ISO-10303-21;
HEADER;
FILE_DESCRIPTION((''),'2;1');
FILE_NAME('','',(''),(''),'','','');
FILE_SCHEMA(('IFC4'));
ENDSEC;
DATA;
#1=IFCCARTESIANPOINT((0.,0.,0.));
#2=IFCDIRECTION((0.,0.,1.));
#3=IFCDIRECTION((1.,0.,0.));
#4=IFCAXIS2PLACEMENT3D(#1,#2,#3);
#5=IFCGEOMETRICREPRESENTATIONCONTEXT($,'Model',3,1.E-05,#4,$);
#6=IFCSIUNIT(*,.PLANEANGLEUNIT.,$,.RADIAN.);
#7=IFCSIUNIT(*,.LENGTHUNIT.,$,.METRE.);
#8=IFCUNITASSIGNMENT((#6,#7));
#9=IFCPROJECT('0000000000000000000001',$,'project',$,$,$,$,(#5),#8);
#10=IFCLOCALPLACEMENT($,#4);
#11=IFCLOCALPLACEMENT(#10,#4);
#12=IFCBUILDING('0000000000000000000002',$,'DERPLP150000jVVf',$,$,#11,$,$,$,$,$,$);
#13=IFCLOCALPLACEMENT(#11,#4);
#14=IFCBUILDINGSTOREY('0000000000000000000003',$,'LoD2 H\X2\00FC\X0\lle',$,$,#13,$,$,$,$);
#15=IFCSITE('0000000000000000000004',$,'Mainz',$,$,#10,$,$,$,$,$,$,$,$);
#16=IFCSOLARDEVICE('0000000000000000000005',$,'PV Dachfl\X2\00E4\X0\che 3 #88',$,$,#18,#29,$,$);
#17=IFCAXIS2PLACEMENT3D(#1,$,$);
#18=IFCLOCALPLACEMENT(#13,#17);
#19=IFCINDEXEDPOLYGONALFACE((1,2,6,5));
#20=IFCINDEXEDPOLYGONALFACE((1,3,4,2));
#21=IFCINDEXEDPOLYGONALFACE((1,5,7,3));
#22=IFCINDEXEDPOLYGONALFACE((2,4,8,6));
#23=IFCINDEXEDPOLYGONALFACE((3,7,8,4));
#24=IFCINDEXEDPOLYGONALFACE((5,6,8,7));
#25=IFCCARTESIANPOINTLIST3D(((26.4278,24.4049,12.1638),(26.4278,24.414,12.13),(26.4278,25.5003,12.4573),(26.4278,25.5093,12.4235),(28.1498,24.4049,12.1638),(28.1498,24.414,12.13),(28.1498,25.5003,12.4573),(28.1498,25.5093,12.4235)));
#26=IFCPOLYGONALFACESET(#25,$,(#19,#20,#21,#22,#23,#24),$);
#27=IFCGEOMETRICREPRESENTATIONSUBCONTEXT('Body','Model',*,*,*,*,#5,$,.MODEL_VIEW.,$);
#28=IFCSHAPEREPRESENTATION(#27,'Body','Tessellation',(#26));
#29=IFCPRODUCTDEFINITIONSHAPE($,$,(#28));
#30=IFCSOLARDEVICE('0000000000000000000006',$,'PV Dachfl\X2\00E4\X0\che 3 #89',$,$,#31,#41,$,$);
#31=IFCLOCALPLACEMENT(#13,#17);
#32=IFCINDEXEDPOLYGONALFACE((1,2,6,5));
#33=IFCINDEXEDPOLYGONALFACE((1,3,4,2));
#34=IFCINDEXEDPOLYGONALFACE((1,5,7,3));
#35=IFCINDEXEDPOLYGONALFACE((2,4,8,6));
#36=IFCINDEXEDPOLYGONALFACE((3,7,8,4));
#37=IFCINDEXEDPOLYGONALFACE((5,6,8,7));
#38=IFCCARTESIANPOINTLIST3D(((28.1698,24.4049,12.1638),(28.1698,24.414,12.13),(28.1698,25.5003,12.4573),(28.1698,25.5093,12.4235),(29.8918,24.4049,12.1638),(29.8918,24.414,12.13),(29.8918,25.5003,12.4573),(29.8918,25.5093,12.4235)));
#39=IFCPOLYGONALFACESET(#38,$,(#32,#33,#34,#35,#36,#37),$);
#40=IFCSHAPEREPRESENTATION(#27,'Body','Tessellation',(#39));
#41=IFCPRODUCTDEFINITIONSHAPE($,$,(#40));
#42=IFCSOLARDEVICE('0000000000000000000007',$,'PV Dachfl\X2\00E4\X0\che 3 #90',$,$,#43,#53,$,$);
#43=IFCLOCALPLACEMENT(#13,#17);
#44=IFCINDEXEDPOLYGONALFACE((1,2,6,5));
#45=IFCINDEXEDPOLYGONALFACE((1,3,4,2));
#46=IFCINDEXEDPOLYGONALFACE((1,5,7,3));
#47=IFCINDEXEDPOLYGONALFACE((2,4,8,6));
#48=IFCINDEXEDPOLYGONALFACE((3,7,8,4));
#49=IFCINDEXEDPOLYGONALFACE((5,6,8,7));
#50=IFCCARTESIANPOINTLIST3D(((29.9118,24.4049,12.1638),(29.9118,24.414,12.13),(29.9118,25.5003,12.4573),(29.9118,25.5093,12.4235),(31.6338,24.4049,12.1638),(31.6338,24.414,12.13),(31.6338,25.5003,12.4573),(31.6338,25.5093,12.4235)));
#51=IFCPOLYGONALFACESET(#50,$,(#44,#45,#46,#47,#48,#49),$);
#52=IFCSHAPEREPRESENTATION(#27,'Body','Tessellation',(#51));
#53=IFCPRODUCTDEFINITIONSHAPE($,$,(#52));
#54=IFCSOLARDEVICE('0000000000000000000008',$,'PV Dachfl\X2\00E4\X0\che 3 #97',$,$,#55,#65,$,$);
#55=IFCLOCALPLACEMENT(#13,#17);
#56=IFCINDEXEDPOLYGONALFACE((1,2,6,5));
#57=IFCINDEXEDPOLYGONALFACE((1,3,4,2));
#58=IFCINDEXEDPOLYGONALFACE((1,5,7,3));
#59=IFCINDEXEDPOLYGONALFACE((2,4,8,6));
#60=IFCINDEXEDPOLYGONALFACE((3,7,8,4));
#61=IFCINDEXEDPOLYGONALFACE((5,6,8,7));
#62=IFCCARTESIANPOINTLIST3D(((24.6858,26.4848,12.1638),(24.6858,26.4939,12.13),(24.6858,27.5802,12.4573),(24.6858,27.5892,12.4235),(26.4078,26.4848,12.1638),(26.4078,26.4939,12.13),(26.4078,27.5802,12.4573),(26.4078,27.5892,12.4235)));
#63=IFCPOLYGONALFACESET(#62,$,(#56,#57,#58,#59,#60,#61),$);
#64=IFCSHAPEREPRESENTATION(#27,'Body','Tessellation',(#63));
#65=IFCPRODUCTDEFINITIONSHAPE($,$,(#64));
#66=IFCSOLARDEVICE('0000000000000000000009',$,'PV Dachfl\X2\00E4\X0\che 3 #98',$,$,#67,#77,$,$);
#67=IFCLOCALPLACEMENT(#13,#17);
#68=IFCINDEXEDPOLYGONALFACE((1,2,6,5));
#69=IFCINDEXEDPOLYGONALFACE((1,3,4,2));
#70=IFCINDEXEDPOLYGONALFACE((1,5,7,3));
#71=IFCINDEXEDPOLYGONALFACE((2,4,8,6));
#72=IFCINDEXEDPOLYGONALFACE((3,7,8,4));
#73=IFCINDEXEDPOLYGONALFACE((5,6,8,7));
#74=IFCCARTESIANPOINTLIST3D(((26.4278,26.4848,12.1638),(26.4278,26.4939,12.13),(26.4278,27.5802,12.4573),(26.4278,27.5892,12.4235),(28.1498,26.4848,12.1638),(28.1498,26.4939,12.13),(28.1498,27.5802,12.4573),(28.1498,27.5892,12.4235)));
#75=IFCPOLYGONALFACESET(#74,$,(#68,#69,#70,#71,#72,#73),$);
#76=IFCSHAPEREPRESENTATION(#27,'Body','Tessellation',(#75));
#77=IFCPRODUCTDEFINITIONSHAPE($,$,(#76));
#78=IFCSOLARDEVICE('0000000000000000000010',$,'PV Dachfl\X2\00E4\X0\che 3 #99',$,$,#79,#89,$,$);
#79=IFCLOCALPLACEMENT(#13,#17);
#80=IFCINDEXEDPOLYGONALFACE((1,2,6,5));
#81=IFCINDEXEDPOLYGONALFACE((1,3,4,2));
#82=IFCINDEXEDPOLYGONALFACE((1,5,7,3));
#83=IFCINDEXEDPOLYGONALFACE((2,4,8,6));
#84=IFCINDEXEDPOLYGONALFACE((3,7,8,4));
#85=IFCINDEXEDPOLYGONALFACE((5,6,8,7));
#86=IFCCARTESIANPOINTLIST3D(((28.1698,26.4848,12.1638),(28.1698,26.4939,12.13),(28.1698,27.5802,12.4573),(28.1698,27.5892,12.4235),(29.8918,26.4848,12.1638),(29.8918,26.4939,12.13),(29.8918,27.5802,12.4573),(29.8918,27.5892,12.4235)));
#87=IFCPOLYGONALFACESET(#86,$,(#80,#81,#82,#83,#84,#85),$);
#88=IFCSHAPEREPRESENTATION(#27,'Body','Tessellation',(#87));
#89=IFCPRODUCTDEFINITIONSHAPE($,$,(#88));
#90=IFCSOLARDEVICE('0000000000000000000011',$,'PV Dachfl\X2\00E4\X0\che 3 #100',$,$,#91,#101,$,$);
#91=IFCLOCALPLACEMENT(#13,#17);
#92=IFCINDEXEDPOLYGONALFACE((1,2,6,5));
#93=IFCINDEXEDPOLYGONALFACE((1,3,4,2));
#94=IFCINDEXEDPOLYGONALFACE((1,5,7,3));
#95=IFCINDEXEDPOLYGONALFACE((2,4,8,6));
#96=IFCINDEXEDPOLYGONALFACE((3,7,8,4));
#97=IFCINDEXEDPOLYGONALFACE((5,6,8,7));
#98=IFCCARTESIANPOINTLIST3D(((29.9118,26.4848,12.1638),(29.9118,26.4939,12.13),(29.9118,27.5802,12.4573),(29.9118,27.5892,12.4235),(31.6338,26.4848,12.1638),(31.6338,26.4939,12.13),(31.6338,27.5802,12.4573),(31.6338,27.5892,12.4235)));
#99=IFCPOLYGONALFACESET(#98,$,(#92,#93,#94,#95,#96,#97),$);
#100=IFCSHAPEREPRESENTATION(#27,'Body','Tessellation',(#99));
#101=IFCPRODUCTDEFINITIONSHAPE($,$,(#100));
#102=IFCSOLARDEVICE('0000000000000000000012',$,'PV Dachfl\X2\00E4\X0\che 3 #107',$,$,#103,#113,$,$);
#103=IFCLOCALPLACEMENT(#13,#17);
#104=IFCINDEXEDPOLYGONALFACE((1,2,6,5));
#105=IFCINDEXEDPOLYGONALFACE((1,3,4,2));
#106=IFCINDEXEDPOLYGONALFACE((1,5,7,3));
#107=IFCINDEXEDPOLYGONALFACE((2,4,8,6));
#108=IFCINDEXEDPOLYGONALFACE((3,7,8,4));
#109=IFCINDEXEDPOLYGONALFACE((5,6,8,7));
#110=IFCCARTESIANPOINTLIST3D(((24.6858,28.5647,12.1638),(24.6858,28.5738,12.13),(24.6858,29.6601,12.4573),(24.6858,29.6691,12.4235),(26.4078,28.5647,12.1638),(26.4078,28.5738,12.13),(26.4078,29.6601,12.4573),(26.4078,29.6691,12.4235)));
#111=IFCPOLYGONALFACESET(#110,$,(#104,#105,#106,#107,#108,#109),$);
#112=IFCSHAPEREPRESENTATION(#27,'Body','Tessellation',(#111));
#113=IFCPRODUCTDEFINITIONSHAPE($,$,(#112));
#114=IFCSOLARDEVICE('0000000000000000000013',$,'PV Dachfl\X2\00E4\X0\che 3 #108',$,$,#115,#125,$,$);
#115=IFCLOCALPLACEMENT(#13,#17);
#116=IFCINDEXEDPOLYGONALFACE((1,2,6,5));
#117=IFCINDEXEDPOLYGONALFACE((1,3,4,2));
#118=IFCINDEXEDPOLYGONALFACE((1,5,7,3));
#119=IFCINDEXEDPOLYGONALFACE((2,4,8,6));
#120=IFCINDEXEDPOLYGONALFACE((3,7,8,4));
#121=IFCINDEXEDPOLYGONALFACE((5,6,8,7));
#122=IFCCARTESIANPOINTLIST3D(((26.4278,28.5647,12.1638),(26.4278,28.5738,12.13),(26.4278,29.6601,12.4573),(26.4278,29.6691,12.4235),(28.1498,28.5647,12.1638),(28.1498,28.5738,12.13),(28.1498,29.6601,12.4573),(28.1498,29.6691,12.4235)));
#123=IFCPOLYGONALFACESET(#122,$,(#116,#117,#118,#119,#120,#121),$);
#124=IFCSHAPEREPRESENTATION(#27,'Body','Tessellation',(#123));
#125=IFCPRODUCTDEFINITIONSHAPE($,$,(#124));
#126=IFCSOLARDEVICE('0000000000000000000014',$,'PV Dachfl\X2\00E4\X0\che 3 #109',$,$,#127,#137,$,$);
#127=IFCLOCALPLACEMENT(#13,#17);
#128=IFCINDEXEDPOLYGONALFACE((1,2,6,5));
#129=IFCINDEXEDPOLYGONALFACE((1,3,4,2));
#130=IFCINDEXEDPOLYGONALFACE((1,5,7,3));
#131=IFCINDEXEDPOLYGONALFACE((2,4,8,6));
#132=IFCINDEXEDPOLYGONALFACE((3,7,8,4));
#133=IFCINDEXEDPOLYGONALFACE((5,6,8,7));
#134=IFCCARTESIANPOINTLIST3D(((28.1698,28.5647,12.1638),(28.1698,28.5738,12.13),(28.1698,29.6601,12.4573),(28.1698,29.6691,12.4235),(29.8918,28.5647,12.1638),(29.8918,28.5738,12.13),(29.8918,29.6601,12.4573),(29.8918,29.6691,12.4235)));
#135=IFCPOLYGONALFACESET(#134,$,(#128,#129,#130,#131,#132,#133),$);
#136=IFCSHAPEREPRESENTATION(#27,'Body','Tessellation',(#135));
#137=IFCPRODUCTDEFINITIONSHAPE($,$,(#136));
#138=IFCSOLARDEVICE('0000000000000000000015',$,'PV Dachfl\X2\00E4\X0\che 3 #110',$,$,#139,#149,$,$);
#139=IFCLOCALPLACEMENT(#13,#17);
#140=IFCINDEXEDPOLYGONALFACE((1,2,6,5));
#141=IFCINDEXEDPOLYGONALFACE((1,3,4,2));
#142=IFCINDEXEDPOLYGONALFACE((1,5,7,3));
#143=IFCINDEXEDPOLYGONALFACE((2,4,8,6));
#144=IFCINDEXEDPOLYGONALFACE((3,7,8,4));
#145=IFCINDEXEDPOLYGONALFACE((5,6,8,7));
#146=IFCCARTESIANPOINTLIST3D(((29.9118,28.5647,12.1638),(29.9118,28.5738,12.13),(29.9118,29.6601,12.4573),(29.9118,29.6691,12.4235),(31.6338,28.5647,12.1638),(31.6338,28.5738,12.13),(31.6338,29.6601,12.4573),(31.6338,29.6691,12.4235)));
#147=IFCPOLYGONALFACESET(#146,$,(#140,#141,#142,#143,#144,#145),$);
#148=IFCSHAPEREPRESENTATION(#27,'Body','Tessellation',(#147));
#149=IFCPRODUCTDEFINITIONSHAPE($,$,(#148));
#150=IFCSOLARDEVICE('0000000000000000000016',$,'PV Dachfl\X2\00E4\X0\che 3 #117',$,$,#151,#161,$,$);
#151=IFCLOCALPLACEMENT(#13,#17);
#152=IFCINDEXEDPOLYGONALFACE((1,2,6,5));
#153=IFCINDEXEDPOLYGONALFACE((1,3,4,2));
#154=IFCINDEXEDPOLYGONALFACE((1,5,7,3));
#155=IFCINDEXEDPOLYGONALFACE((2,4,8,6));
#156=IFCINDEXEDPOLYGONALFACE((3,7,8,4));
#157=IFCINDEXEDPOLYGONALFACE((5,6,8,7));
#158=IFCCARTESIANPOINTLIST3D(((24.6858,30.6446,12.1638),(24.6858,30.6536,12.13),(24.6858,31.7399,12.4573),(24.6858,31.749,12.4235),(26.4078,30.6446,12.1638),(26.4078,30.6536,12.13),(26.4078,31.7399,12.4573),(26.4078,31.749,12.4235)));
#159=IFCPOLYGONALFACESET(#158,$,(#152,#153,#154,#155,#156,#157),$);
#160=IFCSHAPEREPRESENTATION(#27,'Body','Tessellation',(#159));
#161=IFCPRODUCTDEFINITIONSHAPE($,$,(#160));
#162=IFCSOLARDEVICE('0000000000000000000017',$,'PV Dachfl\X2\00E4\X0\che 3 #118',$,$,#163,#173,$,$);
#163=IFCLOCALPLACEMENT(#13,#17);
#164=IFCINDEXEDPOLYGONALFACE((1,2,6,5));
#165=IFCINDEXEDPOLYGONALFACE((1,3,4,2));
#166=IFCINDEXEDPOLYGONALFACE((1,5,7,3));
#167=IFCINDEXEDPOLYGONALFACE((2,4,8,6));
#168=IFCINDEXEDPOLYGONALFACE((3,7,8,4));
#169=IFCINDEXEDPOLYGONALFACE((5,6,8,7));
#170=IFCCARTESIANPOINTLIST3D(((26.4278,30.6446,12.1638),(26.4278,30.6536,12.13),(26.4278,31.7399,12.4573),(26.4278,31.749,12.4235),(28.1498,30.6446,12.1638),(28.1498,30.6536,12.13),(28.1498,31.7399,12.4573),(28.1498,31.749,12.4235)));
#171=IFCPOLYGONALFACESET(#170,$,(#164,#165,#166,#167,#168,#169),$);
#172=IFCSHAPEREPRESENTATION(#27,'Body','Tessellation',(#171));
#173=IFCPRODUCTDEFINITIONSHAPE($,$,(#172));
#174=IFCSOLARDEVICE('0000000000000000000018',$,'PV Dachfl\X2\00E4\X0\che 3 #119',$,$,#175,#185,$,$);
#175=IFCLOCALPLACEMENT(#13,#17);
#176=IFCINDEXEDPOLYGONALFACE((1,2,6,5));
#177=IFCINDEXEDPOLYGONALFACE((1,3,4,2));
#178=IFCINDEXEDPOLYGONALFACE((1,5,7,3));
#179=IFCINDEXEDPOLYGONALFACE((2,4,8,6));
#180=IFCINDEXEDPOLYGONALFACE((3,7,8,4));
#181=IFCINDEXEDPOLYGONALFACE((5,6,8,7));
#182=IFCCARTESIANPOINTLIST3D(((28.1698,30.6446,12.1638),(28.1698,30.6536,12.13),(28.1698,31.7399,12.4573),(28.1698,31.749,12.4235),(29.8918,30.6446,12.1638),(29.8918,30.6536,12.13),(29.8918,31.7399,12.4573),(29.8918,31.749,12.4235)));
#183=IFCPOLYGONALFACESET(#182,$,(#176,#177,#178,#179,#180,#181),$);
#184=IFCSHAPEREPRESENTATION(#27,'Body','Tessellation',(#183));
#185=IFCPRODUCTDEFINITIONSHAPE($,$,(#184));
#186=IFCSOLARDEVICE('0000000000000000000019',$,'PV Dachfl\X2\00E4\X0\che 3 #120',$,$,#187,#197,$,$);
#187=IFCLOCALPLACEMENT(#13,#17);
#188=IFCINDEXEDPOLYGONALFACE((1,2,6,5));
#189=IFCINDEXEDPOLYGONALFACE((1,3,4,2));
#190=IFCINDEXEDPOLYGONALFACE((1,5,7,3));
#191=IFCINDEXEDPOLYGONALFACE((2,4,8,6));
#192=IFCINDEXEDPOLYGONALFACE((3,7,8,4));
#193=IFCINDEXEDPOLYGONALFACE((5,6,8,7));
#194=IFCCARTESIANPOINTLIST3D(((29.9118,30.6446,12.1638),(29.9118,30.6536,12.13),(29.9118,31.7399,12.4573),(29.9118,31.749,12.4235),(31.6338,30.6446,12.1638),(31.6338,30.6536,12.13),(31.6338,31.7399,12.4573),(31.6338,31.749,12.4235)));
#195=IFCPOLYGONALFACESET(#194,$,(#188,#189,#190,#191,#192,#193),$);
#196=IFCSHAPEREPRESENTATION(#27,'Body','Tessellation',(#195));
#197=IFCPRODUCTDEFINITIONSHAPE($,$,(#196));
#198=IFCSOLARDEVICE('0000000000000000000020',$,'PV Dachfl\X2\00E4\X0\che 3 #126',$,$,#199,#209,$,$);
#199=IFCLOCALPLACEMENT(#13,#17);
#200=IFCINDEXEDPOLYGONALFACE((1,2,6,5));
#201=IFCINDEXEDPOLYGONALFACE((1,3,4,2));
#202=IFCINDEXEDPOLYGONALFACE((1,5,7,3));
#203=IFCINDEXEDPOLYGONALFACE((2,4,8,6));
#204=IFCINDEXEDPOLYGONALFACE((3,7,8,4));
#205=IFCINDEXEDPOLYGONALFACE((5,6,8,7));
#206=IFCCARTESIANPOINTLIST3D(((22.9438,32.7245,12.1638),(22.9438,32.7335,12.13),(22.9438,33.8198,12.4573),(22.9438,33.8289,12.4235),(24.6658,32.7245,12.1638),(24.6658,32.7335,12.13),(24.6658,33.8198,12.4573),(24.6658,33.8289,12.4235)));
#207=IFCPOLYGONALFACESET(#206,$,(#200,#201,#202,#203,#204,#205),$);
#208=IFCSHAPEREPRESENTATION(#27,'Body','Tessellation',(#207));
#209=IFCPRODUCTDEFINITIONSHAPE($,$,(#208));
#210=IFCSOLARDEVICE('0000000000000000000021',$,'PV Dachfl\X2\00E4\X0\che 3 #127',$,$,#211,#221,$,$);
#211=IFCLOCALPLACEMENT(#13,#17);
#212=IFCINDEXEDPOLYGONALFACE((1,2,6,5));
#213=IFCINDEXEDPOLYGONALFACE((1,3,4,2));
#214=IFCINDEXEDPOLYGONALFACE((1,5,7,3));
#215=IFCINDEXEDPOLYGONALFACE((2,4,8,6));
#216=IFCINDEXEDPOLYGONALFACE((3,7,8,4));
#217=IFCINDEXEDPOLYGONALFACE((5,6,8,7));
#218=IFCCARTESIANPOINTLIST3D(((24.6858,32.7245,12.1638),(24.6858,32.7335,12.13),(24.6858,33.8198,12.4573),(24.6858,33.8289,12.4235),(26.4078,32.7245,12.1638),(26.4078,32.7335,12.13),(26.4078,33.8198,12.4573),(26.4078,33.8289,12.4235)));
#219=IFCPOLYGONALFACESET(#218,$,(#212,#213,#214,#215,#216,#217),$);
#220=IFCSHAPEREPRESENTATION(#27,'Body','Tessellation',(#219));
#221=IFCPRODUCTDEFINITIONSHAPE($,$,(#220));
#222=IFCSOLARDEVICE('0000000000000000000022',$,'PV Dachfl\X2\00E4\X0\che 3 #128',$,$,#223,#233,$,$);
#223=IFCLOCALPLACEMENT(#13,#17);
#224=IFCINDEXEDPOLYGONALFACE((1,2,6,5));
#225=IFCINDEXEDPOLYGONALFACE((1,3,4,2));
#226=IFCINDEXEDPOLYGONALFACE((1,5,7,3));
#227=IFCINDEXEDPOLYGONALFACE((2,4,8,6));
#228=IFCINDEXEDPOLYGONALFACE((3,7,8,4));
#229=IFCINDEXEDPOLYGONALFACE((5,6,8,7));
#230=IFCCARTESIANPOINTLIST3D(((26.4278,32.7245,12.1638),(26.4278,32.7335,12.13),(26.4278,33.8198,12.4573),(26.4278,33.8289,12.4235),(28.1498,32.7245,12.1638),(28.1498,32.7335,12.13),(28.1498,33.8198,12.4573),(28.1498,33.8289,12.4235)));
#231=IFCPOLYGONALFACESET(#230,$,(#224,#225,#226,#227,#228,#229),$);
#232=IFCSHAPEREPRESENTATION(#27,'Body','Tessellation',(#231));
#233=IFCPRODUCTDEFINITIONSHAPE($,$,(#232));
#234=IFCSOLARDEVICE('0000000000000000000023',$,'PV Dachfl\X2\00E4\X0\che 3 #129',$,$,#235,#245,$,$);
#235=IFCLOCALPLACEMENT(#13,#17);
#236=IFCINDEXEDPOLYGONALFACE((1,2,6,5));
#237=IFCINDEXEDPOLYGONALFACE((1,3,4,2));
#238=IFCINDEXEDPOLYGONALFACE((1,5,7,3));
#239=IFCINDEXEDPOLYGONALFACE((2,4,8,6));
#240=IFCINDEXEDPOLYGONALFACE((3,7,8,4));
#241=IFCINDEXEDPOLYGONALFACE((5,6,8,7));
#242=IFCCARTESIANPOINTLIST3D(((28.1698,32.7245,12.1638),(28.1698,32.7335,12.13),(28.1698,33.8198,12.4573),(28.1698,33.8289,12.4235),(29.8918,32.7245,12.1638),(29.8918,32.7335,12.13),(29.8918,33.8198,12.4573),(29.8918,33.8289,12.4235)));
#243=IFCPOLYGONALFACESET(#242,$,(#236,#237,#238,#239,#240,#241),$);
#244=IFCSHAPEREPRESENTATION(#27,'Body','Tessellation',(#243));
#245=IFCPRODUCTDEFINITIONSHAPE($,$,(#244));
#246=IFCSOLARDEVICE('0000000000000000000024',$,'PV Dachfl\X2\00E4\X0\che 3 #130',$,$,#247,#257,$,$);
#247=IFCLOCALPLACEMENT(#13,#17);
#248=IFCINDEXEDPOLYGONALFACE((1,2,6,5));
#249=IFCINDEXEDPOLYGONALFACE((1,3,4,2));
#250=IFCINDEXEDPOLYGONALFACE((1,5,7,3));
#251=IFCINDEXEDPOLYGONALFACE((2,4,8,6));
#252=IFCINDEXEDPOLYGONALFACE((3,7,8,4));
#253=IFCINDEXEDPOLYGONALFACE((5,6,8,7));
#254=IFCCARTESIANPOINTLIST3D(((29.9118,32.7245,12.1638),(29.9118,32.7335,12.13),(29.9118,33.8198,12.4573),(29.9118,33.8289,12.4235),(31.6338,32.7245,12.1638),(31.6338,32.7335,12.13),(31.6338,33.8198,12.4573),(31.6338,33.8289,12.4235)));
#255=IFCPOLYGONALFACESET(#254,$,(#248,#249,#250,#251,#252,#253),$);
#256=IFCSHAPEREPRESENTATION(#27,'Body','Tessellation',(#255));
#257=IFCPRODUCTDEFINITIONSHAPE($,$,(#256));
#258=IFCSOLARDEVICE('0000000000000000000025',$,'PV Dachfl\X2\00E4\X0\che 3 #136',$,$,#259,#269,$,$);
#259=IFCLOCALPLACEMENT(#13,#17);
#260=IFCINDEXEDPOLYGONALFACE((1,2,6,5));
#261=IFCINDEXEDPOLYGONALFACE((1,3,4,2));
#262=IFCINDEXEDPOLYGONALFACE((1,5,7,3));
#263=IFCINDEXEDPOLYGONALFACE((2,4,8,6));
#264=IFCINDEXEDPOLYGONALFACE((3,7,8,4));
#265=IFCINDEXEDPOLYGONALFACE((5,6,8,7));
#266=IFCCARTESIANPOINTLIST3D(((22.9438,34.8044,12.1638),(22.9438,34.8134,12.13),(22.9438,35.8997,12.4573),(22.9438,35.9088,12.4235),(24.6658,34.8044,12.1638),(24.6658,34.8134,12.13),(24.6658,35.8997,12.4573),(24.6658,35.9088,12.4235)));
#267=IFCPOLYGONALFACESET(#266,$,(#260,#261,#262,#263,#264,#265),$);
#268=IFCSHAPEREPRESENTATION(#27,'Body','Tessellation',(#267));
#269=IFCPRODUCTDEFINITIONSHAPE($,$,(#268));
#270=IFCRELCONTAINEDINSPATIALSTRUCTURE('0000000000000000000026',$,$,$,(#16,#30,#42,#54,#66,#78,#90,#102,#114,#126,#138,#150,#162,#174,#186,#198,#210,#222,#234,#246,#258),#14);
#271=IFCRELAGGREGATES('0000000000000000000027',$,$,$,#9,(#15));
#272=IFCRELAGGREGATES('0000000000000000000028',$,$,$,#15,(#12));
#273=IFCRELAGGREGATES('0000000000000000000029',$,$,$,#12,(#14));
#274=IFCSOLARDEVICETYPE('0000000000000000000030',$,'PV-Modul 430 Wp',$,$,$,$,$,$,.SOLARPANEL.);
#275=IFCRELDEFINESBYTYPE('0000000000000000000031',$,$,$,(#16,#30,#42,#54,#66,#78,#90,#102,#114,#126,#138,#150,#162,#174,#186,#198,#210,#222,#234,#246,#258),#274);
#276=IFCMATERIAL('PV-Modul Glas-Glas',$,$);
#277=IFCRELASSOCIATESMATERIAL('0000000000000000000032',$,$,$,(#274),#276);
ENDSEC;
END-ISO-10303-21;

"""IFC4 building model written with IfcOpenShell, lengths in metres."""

from ifc_helpers import new_model, si_unit, frame, frame_2d, origin, origin_with_axes, place, context, subcontext, project, spatial, rectangle, extrude, source, transform, mapped, material, type_object, type_shapes, element, save


model = new_model("IFC4")

# Units and contexts
model_context = context("Model", 3, precision=1e-05, world=origin_with_axes())
body_context = subcontext(model_context, "Body", "Model", "MODEL_VIEW")
ifc_project = project(units=[si_unit("PLANEANGLEUNIT", "RADIAN"), si_unit("LENGTHUNIT", "METRE")], contexts=[model_context])

# Site, building, storey
site_placement = place(None, origin_with_axes())
site = spatial("IfcSite", under=ifc_project, at=site_placement, Name="Mainz")
building_placement = place(site_placement, origin_with_axes())
building = spatial("IfcBuilding", under=site, at=building_placement, Name="DERPLP150000jVVf")
storey_placement = place(building_placement, origin_with_axes())
storey = spatial("IfcBuildingStorey", under=building, at=storey_placement, Name="LoD2 Hülle")

# Solar devices
ifc_material = material(Name="PV-Modul Glas-Glas")
solar_device_type = type_object("IfcSolarDeviceType", Name="PV-Modul 430 Wp", PredefinedType="SOLARPANEL", material=ifc_material)
shared_shape = source(origin_with_axes(), body_context, "Body", "SweptSolid", [
    extrude(rectangle(XDim=1.722, YDim=1.134, at=frame_2d((0.861, 0.567))), origin(), (0.0, 0.0, 1.0), 0.035),
])
type_shapes(solar_device_type, [shared_shape])
for number, where, z_axis, x_axis, name in (
    (1, (26.4278, 24.414, 12.13), (0.0, -0.258819, 0.965926), (1.0, 0.0, 0.0), "PV Dachfläche 3 #88"),
    (2, (28.1698, 24.414, 12.13), (0.0, -0.258819, 0.965926), (1.0, 0.0, 0.0), "PV Dachfläche 3 #89"),
    (3, (29.9118, 24.414, 12.13), (0.0, -0.258819, 0.965926), (1.0, 0.0, 0.0), "PV Dachfläche 3 #90"),
    (4, (24.6858, 26.4939, 12.13), (0.0, -0.258819, 0.965926), (1.0, 0.0, 0.0), "PV Dachfläche 3 #97"),
    (5, (26.4278, 26.4939, 12.13), (0.0, -0.258819, 0.965926), (1.0, 0.0, 0.0), "PV Dachfläche 3 #98"),
    (6, (28.1698, 26.4939, 12.13), (0.0, -0.258819, 0.965926), (1.0, 0.0, 0.0), "PV Dachfläche 3 #99"),
    (7, (29.9118, 26.4939, 12.13), (0.0, -0.258819, 0.965926), (1.0, 0.0, 0.0), "PV Dachfläche 3 #100"),
    (8, (24.6858, 28.5738, 12.13), (0.0, -0.258819, 0.965926), (1.0, 0.0, 0.0), "PV Dachfläche 3 #107"),
    (9, (26.4278, 28.5738, 12.13), (0.0, -0.258819, 0.965926), (1.0, 0.0, 0.0), "PV Dachfläche 3 #108"),
    (10, (28.1698, 28.5738, 12.13), (0.0, -0.258819, 0.965926), (1.0, 0.0, 0.0), "PV Dachfläche 3 #109"),
    (11, (29.9118, 28.5738, 12.13), (0.0, -0.258819, 0.965926), (1.0, 0.0, 0.0), "PV Dachfläche 3 #110"),
    (12, (24.6858, 30.6536, 12.13), (0.0, -0.258819, 0.965926), (1.0, 0.0, 0.0), "PV Dachfläche 3 #117"),
    (13, (26.4278, 30.6536, 12.13), (0.0, -0.258819, 0.965926), (1.0, 0.0, 0.0), "PV Dachfläche 3 #118"),
    (14, (28.1698, 30.6536, 12.13), (0.0, -0.258819, 0.965926), (1.0, 0.0, 0.0), "PV Dachfläche 3 #119"),
    (15, (29.9118, 30.6536, 12.13), (0.0, -0.258819, 0.965926), (1.0, 0.0, 0.0), "PV Dachfläche 3 #120"),
    (16, (22.9438, 32.7335, 12.13), (0.0, -0.258819, 0.965926), (1.0, 0.0, 0.0), "PV Dachfläche 3 #126"),
    (17, (24.6858, 32.7335, 12.13), (0.0, -0.258819, 0.965926), (1.0, 0.0, 0.0), "PV Dachfläche 3 #127"),
    (18, (26.4278, 32.7335, 12.13), (0.0, -0.258819, 0.965926), (1.0, 0.0, 0.0), "PV Dachfläche 3 #128"),
    (19, (28.1698, 32.7335, 12.13), (0.0, -0.258819, 0.965926), (1.0, 0.0, 0.0), "PV Dachfläche 3 #129"),
    (20, (29.9118, 32.7335, 12.13), (0.0, -0.258819, 0.965926), (1.0, 0.0, 0.0), "PV Dachfläche 3 #130"),
    (21, (22.9438, 34.8134, 12.13), (0.0, -0.258819, 0.965926), (1.0, 0.0, 0.0), "PV Dachfläche 3 #136"),
):
    element("IfcSolarDevice", number, at=place(storey_placement, frame(where, z_axis=z_axis, x_axis=x_axis)), inside=storey, type_object=solar_device_type, Name=name, context=body_context, shape_type="MappedRepresentation", body=[
        mapped(shared_shape, transform((0.0, 0.0, 0.0), x_axis=(1.0, 0.0, 0.0), y_axis=(0.0, 1.0, 0.0), z_axis=(0.0, 0.0, 1.0), scale=1.0)),
    ])

save(model, "model.ifc")
